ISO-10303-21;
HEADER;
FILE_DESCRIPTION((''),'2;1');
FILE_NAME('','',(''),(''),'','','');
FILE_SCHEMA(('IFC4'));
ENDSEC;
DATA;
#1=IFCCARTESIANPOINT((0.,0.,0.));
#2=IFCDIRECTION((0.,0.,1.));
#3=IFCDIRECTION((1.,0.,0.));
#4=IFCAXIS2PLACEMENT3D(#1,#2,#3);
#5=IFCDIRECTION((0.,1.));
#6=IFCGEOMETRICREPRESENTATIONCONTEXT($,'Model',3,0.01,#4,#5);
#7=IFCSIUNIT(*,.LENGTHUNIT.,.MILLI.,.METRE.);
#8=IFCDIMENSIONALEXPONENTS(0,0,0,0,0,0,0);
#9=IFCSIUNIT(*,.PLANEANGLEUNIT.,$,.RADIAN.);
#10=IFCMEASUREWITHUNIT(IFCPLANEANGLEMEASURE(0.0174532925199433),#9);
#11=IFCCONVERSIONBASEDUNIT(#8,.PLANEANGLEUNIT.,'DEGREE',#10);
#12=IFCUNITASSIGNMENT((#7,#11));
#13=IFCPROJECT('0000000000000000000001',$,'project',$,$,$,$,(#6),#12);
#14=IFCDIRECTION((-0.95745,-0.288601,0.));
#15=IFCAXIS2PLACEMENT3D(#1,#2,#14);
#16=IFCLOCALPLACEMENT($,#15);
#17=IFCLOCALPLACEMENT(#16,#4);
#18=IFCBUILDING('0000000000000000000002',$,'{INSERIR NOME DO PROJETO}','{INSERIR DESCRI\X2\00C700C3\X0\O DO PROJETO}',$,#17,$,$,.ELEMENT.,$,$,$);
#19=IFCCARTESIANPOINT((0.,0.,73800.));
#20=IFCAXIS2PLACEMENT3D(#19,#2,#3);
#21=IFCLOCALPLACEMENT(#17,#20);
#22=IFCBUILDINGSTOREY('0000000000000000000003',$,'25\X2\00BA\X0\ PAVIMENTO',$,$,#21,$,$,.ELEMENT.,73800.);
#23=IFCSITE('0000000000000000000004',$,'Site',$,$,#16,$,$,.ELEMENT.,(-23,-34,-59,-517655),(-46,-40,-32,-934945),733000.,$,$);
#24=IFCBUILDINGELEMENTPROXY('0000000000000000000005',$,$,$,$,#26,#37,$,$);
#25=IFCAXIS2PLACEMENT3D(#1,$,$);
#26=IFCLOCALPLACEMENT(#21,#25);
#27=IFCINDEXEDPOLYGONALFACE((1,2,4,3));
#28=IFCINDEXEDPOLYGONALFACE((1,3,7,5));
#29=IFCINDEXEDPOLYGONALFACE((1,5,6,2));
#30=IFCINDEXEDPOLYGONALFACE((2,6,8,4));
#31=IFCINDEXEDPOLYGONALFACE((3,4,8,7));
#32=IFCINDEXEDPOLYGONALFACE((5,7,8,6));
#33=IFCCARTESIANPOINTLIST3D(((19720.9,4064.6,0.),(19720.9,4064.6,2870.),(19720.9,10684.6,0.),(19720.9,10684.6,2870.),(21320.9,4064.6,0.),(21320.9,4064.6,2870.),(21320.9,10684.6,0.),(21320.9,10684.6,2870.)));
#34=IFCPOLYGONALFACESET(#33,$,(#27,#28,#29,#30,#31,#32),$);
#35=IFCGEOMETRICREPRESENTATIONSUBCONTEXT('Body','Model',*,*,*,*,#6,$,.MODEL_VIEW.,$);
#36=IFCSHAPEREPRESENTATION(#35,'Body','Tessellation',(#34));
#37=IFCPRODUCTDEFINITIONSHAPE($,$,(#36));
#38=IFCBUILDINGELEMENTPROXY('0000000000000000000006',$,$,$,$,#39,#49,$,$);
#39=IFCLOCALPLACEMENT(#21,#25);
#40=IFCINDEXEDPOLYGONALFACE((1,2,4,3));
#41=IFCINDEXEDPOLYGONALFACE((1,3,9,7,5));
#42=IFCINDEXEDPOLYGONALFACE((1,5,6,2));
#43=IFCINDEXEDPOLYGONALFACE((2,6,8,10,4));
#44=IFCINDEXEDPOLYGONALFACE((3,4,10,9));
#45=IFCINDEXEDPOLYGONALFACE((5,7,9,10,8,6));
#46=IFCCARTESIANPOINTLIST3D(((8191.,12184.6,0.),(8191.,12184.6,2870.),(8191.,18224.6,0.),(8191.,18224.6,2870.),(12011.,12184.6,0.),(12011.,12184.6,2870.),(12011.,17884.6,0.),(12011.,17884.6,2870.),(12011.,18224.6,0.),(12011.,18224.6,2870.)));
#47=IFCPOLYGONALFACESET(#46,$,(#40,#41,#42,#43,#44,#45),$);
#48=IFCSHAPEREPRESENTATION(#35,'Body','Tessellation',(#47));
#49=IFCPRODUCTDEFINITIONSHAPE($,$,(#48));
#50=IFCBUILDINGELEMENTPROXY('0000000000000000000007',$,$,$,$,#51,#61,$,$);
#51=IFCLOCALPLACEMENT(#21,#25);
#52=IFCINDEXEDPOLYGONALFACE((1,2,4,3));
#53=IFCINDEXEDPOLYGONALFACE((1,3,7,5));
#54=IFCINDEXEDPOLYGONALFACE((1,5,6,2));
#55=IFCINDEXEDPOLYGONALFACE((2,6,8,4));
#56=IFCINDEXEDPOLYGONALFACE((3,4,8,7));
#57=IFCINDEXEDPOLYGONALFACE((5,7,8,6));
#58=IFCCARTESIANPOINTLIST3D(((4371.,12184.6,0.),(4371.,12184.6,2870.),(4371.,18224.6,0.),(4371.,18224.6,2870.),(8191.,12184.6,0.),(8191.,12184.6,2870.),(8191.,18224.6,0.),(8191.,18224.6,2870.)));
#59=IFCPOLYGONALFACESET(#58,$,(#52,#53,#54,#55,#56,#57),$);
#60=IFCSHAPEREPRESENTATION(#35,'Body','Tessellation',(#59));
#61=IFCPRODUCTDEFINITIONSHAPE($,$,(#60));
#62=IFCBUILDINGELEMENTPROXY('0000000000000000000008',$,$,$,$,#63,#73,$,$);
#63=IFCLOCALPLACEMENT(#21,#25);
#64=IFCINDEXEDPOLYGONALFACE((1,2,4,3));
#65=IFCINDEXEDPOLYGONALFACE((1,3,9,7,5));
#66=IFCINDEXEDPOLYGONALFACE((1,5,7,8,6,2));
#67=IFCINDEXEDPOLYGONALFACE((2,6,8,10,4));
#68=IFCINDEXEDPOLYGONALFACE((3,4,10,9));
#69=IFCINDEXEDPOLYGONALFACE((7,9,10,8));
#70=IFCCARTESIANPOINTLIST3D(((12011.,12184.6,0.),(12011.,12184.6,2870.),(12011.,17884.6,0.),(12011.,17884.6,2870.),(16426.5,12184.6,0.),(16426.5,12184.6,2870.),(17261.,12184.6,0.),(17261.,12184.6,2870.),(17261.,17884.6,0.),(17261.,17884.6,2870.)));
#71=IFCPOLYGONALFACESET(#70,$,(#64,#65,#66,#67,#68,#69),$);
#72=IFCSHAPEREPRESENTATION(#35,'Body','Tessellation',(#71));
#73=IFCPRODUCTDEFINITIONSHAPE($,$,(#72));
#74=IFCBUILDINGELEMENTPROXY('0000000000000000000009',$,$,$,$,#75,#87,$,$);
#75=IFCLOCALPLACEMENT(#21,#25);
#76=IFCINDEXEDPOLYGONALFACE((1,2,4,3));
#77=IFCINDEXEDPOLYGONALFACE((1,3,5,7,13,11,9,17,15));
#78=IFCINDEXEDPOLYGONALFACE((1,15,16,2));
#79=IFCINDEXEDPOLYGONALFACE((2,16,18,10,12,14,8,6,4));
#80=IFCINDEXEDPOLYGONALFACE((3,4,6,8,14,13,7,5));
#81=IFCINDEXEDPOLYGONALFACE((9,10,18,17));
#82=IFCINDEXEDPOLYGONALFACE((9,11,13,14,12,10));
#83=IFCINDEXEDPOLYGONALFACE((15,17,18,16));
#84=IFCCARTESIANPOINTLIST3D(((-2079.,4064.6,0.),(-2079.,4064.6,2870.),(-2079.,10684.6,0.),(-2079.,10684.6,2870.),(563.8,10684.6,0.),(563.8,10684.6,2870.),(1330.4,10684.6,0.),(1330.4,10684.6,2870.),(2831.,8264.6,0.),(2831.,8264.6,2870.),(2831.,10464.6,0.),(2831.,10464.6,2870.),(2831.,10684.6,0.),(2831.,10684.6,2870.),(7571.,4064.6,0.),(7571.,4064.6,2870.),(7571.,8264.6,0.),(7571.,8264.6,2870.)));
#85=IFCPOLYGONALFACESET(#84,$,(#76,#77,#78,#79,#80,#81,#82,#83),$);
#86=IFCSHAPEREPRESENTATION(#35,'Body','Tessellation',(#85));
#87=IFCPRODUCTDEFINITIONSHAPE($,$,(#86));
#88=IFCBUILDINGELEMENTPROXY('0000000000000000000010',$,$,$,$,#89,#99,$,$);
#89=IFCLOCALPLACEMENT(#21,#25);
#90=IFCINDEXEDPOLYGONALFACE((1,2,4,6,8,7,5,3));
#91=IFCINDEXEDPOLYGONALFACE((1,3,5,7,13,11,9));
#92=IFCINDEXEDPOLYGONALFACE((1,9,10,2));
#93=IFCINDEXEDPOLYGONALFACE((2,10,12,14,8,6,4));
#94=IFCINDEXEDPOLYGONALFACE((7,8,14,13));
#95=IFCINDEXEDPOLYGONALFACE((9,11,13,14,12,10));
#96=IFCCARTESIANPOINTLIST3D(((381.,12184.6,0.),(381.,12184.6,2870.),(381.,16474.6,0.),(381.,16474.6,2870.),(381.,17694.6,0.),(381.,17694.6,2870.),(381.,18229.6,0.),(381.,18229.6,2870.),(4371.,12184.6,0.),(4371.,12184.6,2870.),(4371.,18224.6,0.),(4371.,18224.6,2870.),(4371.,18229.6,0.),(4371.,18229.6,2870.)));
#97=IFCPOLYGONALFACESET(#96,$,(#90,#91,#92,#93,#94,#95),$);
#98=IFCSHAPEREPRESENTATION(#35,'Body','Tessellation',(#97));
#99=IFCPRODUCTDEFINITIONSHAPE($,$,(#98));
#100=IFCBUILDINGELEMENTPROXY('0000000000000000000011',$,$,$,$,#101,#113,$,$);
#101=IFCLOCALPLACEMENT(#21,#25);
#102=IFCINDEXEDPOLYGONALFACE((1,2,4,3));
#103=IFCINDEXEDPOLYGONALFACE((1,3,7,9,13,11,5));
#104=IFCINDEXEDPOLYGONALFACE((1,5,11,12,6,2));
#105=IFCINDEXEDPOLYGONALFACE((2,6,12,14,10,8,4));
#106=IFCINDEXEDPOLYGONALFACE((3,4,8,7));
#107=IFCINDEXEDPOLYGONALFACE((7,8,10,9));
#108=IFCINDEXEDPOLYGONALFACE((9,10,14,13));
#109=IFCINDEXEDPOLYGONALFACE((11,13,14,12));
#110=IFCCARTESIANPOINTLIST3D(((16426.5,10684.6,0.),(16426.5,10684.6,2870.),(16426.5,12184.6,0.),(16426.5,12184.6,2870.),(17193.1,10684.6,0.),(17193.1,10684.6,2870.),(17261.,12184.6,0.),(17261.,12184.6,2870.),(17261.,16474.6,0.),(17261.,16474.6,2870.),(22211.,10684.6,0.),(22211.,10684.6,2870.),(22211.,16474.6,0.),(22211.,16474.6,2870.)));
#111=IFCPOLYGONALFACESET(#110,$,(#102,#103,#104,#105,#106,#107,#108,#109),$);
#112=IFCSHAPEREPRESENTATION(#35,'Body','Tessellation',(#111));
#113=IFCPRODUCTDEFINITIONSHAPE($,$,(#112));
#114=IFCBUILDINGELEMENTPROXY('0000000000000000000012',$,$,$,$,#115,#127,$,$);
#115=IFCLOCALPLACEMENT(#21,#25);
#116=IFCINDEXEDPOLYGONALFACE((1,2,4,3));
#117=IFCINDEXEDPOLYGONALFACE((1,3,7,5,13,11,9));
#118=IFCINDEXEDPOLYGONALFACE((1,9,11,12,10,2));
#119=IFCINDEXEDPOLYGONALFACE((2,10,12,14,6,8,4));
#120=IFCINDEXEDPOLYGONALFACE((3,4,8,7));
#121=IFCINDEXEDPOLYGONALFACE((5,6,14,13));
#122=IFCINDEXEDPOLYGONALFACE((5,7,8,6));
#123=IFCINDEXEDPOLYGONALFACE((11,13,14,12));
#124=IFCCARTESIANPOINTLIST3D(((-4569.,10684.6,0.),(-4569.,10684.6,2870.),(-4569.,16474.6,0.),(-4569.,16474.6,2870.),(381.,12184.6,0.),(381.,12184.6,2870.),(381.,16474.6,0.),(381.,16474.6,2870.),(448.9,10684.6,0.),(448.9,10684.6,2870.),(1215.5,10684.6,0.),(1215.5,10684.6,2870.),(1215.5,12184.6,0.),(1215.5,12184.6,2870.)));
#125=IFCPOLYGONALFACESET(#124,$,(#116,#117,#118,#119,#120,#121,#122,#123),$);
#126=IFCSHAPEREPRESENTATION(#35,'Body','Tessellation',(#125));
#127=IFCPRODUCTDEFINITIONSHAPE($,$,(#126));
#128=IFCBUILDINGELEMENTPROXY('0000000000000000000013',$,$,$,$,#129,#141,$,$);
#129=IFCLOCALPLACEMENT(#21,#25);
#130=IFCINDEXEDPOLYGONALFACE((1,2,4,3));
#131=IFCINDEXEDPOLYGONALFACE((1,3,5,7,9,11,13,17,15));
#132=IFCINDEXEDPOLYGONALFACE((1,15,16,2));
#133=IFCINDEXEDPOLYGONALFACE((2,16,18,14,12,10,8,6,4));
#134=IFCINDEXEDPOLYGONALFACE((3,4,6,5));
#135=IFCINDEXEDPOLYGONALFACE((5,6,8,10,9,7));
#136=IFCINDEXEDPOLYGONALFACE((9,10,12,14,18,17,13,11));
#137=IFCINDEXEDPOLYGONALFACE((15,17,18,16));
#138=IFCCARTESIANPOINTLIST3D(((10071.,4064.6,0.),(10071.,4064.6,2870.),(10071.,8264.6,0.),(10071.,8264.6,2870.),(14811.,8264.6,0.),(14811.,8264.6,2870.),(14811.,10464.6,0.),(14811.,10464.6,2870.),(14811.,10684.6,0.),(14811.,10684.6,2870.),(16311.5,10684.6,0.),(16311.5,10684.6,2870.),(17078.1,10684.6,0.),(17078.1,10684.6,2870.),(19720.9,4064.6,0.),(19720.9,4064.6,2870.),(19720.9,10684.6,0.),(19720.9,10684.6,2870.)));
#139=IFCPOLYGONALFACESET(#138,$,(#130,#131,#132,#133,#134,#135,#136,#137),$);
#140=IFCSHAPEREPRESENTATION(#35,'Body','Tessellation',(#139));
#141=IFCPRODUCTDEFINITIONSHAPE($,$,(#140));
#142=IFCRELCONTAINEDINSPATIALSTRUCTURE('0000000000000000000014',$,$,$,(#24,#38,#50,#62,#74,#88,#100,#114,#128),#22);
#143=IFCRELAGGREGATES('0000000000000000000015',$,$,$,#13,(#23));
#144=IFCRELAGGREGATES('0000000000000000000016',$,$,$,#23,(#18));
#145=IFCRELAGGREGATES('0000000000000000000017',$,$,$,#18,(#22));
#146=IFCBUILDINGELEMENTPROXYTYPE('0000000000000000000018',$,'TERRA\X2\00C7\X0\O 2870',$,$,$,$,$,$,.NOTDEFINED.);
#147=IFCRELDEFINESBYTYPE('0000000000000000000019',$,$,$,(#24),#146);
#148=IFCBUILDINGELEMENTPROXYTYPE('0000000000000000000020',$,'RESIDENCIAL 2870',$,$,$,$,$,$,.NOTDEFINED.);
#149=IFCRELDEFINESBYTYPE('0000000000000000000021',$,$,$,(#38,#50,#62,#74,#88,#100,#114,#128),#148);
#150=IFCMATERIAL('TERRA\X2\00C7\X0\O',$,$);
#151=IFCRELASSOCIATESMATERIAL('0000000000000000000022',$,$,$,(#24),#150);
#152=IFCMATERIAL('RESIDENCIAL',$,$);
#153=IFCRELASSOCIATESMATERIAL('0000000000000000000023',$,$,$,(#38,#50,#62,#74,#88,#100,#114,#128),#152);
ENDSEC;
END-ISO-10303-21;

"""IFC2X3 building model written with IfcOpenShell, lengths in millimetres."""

from ifc_helpers import new_model, entity, si_unit, converted_unit, direction, frame, origin_with_axes, place, context, subcontext, project, spatial, polyline, outline, extrude, material, type_object, element, save


model = new_model("IFC2X3")

# Units and contexts
model_context = context("Model", 3, precision=0.01, world=origin_with_axes(), true_north=direction((0.0, 1.0)))
body_context = subcontext(model_context, "Body", "Model", "MODEL_VIEW")
ifc_project = project(units=[si_unit("LENGTHUNIT", "METRE", prefix="MILLI"), converted_unit("PLANEANGLEUNIT", "DEGREE", entity("IfcPlaneAngleMeasure", 0.0174532925199433), si_unit("PLANEANGLEUNIT", "RADIAN"), dimensions=[0, 0, 0, 0, 0, 0, 0])], contexts=[model_context])

# Site, building, storey
site_placement = place(None, frame((0.0, 0.0, 0.0), z_axis=(0.0, 0.0, 1.0), x_axis=(-0.95745, -0.288601, 0.0)))
site = spatial("IfcSite", under=ifc_project, at=site_placement, Name="Site", CompositionType="ELEMENT", RefLatitude=(-23, -34, -59, -517655), RefLongitude=(-46, -40, -32, -934945), RefElevation=733000.0)
building_placement = place(site_placement, origin_with_axes())
building = spatial("IfcBuilding", under=site, at=building_placement, Name="{INSERIR NOME DO PROJETO}", Description="{INSERIR DESCRIÇÃO DO PROJETO}", CompositionType="ELEMENT")
storey_placement = place(building_placement, frame((0.0, 0.0, 73800.0), z_axis=(0.0, 0.0, 1.0), x_axis=(1.0, 0.0, 0.0)))
storey = spatial("IfcBuildingStorey", under=building, at=storey_placement, Name="25º PAVIMENTO", CompositionType="ELEMENT", Elevation=73800.0)

# Building element proxies
ifc_material_1 = material(Name="TERRAÇO")
building_element_proxy_type_1 = type_object("IfcBuildingElementProxyType", Name="TERRAÇO 2870", PredefinedType="NOTDEFINED")
proxy_1_placement = place(storey_placement, frame((21320.9, 4064.6, 0.0), z_axis=(0.0, 0.0, 1.0), x_axis=(1.0, 0.0, 0.0)))
element("IfcBuildingElementProxy", 1, at=proxy_1_placement, inside=storey, type_object=building_element_proxy_type_1, material=ifc_material_1, context=body_context, shape_type="SweptSolid", body=[
    extrude(outline(polyline([(0.0, 0.0), (0.0, 6620.0), (-1600.0, 6620.0), (-1600.0, 0.0), (0.0, 0.0)])), origin_with_axes(), (0.0, 0.0, 1.0), 2870.0),
])
ifc_material_2 = material(Name="RESIDENCIAL")
building_element_proxy_type_2 = type_object("IfcBuildingElementProxyType", Name="RESIDENCIAL 2870", PredefinedType="NOTDEFINED")
proxy_2_placement = place(storey_placement, frame((8191.0, 18224.6, 0.0), z_axis=(0.0, 0.0, 1.0), x_axis=(1.0, 0.0, 0.0)))
element("IfcBuildingElementProxy", 2, at=proxy_2_placement, inside=storey, type_object=building_element_proxy_type_2, material=ifc_material_2, context=body_context, shape_type="SweptSolid", body=[
    extrude(outline(polyline([(0.0, 0.0), (0.0, -6040.0), (3820.0, -6040.0), (3820.0, -340.0), (3820.0, 0.0), (0.0, 0.0)])), origin_with_axes(), (0.0, 0.0, 1.0), 2870.0),
])
proxy_3_placement = place(storey_placement, frame((4371.0, 18224.6, 0.0), z_axis=(0.0, 0.0, 1.0), x_axis=(1.0, 0.0, 0.0)))
element("IfcBuildingElementProxy", 3, at=proxy_3_placement, inside=storey, type_object=building_element_proxy_type_2, material=ifc_material_2, context=body_context, shape_type="SweptSolid", body=[
    extrude(outline(polyline([(0.0, 0.0), (0.0, -6040.0), (3820.0, -6040.0), (3820.0, 0.0), (0.0, 0.0)])), origin_with_axes(), (0.0, 0.0, 1.0), 2870.0),
])
proxy_4_placement = place(storey_placement, frame((12011.0, 12184.6, 0.0), z_axis=(0.0, 0.0, 1.0), x_axis=(1.0, 0.0, 0.0)))
element("IfcBuildingElementProxy", 4, at=proxy_4_placement, inside=storey, type_object=building_element_proxy_type_2, material=ifc_material_2, context=body_context, shape_type="SweptSolid", body=[
    extrude(outline(polyline([(0.0, 0.0), (4415.5, 0.0), (5250.0, 0.0), (5250.0, 5700.0), (0.0, 5700.0), (0.0, 0.0)])), origin_with_axes(), (0.0, 0.0, 1.0), 2870.0),
])
proxy_5_placement = place(storey_placement, frame((-2079.0, 4064.6, 0.0), z_axis=(0.0, 0.0, 1.0), x_axis=(1.0, 0.0, 0.0)))
element("IfcBuildingElementProxy", 5, at=proxy_5_placement, inside=storey, type_object=building_element_proxy_type_2, material=ifc_material_2, context=body_context, shape_type="SweptSolid", body=[
    extrude(outline(polyline([(0.0, 0.0), (9650.0, 0.0), (9650.0, 4200.0), (4910.0, 4200.0), (4910.0, 6400.0), (4910.0, 6620.0), (3409.4, 6620.0), (2642.8, 6620.0), (0.0, 6620.0), (0.0, 0.0)])), origin_with_axes(), (0.0, 0.0, 1.0), 2870.0),
])
proxy_6_placement = place(storey_placement, frame((381.0, 16474.6, 0.0), z_axis=(0.0, 0.0, 1.0), x_axis=(1.0, 0.0, 0.0)))
element("IfcBuildingElementProxy", 6, at=proxy_6_placement, inside=storey, type_object=building_element_proxy_type_2, material=ifc_material_2, context=body_context, shape_type="SweptSolid", body=[
    extrude(outline(polyline([(0.0, 0.0), (0.0, -4290.0), (3990.0, -4290.0), (3990.0, 1750.0), (3990.0, 1755.0), (0.0, 1755.0), (0.0, 1220.0), (0.0, 0.0)])), origin_with_axes(), (0.0, 0.0, 1.0), 2870.0),
])
proxy_7_placement = place(storey_placement, frame((17261.0, 12184.6, 0.0), z_axis=(0.0, 0.0, 1.0), x_axis=(1.0, 0.0, 0.0)))
element("IfcBuildingElementProxy", 7, at=proxy_7_placement, inside=storey, type_object=building_element_proxy_type_2, material=ifc_material_2, context=body_context, shape_type="SweptSolid", body=[
    extrude(outline(polyline([(0.0, 0.0), (-834.5, 0.0), (-834.5, -1500.0), (-67.9, -1500.0), (4950.0, -1500.0), (4950.0, 4290.0), (0.0, 4290.0), (0.0, 0.0)])), origin_with_axes(), (0.0, 0.0, 1.0), 2870.0),
])
proxy_8_placement = place(storey_placement, frame((-4569.0, 16474.6, 0.0), z_axis=(0.0, 0.0, 1.0), x_axis=(1.0, 0.0, 0.0)))
element("IfcBuildingElementProxy", 8, at=proxy_8_placement, inside=storey, type_object=building_element_proxy_type_2, material=ifc_material_2, context=body_context, shape_type="SweptSolid", body=[
    extrude(outline(polyline([(0.0, 0.0), (0.0, -5790.0), (5017.9, -5790.0), (5784.5, -5790.0), (5784.5, -4290.0), (4950.0, -4290.0), (4950.0, 0.0), (0.0, 0.0)])), origin_with_axes(), (0.0, 0.0, 1.0), 2870.0),
])
proxy_9_placement = place(storey_placement, frame((19720.9, 4064.6, 0.0), z_axis=(0.0, 0.0, 1.0), x_axis=(1.0, 0.0, 0.0)))
element("IfcBuildingElementProxy", 9, at=proxy_9_placement, inside=storey, type_object=building_element_proxy_type_2, material=ifc_material_2, context=body_context, shape_type="SweptSolid", body=[
    extrude(outline(polyline([(0.0, 0.0), (0.0, 6620.0), (-2642.8, 6620.0), (-3409.4, 6620.0), (-4910.0, 6620.0), (-4910.0, 6400.0), (-4910.0, 4200.0), (-9650.0, 4200.0), (-9650.0, 0.0), (0.0, 0.0)])), origin_with_axes(), (0.0, 0.0, 1.0), 2870.0),
])

save(model, "model.ifc")
